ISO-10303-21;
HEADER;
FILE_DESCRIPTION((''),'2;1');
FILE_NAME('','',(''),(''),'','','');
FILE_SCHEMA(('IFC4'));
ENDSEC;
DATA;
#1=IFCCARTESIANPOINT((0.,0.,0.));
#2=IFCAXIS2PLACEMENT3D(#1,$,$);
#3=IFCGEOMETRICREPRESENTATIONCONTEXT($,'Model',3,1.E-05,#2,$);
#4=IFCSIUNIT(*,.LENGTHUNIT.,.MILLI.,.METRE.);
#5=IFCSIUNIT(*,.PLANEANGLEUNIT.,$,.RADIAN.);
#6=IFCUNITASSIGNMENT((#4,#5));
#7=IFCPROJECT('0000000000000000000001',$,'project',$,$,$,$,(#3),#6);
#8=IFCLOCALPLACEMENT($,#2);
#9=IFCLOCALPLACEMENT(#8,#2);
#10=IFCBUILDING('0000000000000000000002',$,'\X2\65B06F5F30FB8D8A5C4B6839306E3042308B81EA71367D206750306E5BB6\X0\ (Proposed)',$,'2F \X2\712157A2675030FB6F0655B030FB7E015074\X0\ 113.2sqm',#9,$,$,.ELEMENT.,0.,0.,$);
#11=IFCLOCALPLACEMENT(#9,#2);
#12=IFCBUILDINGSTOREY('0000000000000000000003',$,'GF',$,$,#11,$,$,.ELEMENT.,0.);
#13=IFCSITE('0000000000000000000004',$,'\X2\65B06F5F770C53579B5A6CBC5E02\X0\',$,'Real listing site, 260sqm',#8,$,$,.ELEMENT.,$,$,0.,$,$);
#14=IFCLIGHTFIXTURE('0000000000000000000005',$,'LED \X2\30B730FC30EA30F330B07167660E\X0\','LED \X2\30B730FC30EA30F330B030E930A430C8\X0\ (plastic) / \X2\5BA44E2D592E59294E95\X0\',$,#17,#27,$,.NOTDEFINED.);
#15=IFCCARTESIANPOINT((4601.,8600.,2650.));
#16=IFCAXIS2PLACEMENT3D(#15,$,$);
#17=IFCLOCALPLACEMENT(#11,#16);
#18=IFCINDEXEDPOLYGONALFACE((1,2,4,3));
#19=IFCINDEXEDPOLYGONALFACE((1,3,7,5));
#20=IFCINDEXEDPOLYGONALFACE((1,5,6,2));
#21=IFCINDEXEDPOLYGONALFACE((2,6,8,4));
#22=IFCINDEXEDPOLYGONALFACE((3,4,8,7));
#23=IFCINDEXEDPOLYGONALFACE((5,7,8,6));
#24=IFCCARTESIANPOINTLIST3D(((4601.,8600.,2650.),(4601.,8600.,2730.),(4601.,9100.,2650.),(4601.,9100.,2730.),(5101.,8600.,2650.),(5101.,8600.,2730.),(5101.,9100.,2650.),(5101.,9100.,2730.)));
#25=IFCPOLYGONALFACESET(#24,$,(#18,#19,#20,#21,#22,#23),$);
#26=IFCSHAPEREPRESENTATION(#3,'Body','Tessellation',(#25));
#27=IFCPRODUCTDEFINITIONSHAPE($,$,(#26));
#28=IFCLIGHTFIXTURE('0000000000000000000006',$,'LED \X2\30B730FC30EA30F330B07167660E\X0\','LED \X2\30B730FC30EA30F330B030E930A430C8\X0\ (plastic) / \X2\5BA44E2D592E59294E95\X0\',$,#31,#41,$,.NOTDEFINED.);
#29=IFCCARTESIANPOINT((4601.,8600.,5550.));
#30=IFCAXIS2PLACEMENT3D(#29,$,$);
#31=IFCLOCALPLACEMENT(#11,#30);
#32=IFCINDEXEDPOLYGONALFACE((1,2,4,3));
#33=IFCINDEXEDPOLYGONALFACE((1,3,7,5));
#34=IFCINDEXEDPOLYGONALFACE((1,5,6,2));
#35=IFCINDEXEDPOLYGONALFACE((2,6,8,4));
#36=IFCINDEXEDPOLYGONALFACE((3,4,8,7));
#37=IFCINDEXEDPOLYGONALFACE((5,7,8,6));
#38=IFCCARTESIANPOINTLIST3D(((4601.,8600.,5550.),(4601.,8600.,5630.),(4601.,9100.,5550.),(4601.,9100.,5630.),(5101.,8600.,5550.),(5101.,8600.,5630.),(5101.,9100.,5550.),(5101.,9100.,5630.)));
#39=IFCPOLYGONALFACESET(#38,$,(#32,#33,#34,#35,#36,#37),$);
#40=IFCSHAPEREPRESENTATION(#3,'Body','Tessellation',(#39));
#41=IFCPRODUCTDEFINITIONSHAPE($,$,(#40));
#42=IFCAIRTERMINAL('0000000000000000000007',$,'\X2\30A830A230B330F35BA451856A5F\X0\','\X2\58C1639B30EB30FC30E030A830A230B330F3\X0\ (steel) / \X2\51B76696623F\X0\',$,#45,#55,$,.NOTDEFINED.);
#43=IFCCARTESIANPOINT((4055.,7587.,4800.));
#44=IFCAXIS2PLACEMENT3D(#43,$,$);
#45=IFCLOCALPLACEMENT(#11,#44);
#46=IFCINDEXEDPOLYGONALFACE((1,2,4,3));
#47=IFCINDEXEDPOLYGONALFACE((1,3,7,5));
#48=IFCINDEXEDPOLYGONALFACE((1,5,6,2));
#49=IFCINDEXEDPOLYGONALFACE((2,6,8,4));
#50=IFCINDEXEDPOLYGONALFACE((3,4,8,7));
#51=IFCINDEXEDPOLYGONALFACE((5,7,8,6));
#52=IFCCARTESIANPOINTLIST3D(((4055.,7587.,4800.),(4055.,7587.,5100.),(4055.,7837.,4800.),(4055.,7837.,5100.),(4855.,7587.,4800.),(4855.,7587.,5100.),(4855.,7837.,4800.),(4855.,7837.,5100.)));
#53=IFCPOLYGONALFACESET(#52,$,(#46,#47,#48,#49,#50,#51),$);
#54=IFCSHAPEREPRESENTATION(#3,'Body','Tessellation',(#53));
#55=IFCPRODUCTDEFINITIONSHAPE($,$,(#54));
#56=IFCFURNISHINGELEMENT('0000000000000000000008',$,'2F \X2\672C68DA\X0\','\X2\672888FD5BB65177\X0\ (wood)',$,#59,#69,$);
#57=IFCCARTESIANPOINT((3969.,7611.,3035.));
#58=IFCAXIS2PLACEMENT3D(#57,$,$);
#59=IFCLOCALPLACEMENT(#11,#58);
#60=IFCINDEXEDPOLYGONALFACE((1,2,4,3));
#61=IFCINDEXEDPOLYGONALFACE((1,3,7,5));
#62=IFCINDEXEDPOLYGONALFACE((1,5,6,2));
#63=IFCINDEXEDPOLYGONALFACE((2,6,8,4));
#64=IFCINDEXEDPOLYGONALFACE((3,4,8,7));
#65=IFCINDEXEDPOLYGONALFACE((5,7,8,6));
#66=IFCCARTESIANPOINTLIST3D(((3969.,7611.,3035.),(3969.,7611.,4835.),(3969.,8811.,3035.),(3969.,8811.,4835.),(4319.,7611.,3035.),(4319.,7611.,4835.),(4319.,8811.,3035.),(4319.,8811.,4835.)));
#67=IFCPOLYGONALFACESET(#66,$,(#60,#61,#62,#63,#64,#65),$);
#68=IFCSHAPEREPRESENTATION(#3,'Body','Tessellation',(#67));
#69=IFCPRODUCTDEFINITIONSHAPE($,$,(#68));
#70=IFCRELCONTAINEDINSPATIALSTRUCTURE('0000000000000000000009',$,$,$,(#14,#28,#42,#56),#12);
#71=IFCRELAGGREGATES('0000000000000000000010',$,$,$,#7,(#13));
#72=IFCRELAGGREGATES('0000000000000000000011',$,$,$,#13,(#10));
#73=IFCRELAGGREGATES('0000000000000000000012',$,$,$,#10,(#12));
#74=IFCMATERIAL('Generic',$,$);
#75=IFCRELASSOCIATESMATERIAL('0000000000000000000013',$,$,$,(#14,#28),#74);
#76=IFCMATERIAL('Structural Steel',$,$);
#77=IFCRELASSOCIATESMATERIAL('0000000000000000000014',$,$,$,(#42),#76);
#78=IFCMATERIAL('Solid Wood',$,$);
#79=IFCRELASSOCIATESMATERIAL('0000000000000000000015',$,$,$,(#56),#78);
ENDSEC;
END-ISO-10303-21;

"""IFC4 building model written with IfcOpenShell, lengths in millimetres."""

from ifc_helpers import new_model, si_unit, frame, frame_2d, origin, place, context, project, spatial, rectangle, extrude, material, element, save


model = new_model("IFC4")

# Units and contexts
model_context = context("Model", 3, precision=1e-05, world=origin())
ifc_project = project(units=[si_unit("LENGTHUNIT", "METRE", prefix="MILLI"), si_unit("PLANEANGLEUNIT", "RADIAN")], contexts=[model_context])

# Site, building, storey
site_placement = place(None, origin())
site = spatial("IfcSite", under=ifc_project, at=site_placement, Name="新潟県南魚沼市", ObjectType="Real listing site, 260sqm", CompositionType="ELEMENT", RefElevation=0.0)
building_placement = place(site_placement, origin())
building = spatial("IfcBuilding", under=site, at=building_placement, Name="新潟・越屋根のある自然素材の家 (Proposed)", ObjectType="2F 無垢材・漆喰・縁側 113.2sqm", CompositionType="ELEMENT", ElevationOfRefHeight=0.0, ElevationOfTerrain=0.0)
storey_placement = place(building_placement, origin())
storey = spatial("IfcBuildingStorey", under=building, at=storey_placement, Name="GF", CompositionType="ELEMENT", Elevation=0.0)

# Shared definitions
ifc_material_1 = material(Name="Solid Wood")

# Shared definitions
ifc_material_2 = material(Name="Structural Steel")

# Shared definitions
ifc_material_3 = material(Name="Generic")

# Light fixtures
light_fixture_1_placement = place(storey_placement, frame((4601.0, 8600.0, 2650.0)))
element("IfcLightFixture", 1, at=light_fixture_1_placement, inside=storey, material=ifc_material_3, Name="LED シーリング照明", Description="LED シーリングライト (plastic) / 室中央天井", PredefinedType="NOTDEFINED", context=model_context, shape_type="SweptSolid", body=[
    extrude(rectangle(XDim=500.0, YDim=500.0, at=frame_2d((250.0, 250.0))), frame((4601.0, 8600.0, 2650.0)), (0.0, 0.0, 1.0), 80.0),
])
light_fixture_2_placement = place(storey_placement, frame((4601.0, 8600.0, 5550.0)))
element("IfcLightFixture", 2, at=light_fixture_2_placement, inside=storey, material=ifc_material_3, Name="LED シーリング照明", Description="LED シーリングライト (plastic) / 室中央天井", PredefinedType="NOTDEFINED", context=model_context, shape_type="SweptSolid", body=[
    extrude(rectangle(XDim=500.0, YDim=500.0, at=frame_2d((250.0, 250.0))), frame((4601.0, 8600.0, 5550.0)), (0.0, 0.0, 1.0), 80.0),
])

# Air terminal
air_terminal_placement = place(storey_placement, frame((4055.0, 7587.0, 4800.0)))
element("IfcAirTerminal", 3, at=air_terminal_placement, inside=storey, material=ifc_material_2, Name="エアコン室内機", Description="壁掛ルームエアコン (steel) / 冷暖房", PredefinedType="NOTDEFINED", context=model_context, shape_type="SweptSolid", body=[
    extrude(rectangle(XDim=800.0, YDim=250.0, at=frame_2d((400.0, 125.0))), frame((4055.0, 7587.0, 4800.0)), (0.0, 0.0, 1.0), 300.0),
])

# Furnishing element
furnishing_placement = place(storey_placement, frame((3969.0, 7611.0, 3035.0)))
element("IfcFurnishingElement", 4, at=furnishing_placement, inside=storey, material=ifc_material_1, Name="2F 本棚", Description="木製家具 (wood)", context=model_context, shape_type="SweptSolid", body=[
    extrude(rectangle(XDim=350.0, YDim=1200.0, at=frame_2d((175.0, 600.0))), frame((3969.0, 7611.0, 3035.0)), (0.0, 0.0, 1.0), 1800.0),
])

save(model, "model.ifc")
